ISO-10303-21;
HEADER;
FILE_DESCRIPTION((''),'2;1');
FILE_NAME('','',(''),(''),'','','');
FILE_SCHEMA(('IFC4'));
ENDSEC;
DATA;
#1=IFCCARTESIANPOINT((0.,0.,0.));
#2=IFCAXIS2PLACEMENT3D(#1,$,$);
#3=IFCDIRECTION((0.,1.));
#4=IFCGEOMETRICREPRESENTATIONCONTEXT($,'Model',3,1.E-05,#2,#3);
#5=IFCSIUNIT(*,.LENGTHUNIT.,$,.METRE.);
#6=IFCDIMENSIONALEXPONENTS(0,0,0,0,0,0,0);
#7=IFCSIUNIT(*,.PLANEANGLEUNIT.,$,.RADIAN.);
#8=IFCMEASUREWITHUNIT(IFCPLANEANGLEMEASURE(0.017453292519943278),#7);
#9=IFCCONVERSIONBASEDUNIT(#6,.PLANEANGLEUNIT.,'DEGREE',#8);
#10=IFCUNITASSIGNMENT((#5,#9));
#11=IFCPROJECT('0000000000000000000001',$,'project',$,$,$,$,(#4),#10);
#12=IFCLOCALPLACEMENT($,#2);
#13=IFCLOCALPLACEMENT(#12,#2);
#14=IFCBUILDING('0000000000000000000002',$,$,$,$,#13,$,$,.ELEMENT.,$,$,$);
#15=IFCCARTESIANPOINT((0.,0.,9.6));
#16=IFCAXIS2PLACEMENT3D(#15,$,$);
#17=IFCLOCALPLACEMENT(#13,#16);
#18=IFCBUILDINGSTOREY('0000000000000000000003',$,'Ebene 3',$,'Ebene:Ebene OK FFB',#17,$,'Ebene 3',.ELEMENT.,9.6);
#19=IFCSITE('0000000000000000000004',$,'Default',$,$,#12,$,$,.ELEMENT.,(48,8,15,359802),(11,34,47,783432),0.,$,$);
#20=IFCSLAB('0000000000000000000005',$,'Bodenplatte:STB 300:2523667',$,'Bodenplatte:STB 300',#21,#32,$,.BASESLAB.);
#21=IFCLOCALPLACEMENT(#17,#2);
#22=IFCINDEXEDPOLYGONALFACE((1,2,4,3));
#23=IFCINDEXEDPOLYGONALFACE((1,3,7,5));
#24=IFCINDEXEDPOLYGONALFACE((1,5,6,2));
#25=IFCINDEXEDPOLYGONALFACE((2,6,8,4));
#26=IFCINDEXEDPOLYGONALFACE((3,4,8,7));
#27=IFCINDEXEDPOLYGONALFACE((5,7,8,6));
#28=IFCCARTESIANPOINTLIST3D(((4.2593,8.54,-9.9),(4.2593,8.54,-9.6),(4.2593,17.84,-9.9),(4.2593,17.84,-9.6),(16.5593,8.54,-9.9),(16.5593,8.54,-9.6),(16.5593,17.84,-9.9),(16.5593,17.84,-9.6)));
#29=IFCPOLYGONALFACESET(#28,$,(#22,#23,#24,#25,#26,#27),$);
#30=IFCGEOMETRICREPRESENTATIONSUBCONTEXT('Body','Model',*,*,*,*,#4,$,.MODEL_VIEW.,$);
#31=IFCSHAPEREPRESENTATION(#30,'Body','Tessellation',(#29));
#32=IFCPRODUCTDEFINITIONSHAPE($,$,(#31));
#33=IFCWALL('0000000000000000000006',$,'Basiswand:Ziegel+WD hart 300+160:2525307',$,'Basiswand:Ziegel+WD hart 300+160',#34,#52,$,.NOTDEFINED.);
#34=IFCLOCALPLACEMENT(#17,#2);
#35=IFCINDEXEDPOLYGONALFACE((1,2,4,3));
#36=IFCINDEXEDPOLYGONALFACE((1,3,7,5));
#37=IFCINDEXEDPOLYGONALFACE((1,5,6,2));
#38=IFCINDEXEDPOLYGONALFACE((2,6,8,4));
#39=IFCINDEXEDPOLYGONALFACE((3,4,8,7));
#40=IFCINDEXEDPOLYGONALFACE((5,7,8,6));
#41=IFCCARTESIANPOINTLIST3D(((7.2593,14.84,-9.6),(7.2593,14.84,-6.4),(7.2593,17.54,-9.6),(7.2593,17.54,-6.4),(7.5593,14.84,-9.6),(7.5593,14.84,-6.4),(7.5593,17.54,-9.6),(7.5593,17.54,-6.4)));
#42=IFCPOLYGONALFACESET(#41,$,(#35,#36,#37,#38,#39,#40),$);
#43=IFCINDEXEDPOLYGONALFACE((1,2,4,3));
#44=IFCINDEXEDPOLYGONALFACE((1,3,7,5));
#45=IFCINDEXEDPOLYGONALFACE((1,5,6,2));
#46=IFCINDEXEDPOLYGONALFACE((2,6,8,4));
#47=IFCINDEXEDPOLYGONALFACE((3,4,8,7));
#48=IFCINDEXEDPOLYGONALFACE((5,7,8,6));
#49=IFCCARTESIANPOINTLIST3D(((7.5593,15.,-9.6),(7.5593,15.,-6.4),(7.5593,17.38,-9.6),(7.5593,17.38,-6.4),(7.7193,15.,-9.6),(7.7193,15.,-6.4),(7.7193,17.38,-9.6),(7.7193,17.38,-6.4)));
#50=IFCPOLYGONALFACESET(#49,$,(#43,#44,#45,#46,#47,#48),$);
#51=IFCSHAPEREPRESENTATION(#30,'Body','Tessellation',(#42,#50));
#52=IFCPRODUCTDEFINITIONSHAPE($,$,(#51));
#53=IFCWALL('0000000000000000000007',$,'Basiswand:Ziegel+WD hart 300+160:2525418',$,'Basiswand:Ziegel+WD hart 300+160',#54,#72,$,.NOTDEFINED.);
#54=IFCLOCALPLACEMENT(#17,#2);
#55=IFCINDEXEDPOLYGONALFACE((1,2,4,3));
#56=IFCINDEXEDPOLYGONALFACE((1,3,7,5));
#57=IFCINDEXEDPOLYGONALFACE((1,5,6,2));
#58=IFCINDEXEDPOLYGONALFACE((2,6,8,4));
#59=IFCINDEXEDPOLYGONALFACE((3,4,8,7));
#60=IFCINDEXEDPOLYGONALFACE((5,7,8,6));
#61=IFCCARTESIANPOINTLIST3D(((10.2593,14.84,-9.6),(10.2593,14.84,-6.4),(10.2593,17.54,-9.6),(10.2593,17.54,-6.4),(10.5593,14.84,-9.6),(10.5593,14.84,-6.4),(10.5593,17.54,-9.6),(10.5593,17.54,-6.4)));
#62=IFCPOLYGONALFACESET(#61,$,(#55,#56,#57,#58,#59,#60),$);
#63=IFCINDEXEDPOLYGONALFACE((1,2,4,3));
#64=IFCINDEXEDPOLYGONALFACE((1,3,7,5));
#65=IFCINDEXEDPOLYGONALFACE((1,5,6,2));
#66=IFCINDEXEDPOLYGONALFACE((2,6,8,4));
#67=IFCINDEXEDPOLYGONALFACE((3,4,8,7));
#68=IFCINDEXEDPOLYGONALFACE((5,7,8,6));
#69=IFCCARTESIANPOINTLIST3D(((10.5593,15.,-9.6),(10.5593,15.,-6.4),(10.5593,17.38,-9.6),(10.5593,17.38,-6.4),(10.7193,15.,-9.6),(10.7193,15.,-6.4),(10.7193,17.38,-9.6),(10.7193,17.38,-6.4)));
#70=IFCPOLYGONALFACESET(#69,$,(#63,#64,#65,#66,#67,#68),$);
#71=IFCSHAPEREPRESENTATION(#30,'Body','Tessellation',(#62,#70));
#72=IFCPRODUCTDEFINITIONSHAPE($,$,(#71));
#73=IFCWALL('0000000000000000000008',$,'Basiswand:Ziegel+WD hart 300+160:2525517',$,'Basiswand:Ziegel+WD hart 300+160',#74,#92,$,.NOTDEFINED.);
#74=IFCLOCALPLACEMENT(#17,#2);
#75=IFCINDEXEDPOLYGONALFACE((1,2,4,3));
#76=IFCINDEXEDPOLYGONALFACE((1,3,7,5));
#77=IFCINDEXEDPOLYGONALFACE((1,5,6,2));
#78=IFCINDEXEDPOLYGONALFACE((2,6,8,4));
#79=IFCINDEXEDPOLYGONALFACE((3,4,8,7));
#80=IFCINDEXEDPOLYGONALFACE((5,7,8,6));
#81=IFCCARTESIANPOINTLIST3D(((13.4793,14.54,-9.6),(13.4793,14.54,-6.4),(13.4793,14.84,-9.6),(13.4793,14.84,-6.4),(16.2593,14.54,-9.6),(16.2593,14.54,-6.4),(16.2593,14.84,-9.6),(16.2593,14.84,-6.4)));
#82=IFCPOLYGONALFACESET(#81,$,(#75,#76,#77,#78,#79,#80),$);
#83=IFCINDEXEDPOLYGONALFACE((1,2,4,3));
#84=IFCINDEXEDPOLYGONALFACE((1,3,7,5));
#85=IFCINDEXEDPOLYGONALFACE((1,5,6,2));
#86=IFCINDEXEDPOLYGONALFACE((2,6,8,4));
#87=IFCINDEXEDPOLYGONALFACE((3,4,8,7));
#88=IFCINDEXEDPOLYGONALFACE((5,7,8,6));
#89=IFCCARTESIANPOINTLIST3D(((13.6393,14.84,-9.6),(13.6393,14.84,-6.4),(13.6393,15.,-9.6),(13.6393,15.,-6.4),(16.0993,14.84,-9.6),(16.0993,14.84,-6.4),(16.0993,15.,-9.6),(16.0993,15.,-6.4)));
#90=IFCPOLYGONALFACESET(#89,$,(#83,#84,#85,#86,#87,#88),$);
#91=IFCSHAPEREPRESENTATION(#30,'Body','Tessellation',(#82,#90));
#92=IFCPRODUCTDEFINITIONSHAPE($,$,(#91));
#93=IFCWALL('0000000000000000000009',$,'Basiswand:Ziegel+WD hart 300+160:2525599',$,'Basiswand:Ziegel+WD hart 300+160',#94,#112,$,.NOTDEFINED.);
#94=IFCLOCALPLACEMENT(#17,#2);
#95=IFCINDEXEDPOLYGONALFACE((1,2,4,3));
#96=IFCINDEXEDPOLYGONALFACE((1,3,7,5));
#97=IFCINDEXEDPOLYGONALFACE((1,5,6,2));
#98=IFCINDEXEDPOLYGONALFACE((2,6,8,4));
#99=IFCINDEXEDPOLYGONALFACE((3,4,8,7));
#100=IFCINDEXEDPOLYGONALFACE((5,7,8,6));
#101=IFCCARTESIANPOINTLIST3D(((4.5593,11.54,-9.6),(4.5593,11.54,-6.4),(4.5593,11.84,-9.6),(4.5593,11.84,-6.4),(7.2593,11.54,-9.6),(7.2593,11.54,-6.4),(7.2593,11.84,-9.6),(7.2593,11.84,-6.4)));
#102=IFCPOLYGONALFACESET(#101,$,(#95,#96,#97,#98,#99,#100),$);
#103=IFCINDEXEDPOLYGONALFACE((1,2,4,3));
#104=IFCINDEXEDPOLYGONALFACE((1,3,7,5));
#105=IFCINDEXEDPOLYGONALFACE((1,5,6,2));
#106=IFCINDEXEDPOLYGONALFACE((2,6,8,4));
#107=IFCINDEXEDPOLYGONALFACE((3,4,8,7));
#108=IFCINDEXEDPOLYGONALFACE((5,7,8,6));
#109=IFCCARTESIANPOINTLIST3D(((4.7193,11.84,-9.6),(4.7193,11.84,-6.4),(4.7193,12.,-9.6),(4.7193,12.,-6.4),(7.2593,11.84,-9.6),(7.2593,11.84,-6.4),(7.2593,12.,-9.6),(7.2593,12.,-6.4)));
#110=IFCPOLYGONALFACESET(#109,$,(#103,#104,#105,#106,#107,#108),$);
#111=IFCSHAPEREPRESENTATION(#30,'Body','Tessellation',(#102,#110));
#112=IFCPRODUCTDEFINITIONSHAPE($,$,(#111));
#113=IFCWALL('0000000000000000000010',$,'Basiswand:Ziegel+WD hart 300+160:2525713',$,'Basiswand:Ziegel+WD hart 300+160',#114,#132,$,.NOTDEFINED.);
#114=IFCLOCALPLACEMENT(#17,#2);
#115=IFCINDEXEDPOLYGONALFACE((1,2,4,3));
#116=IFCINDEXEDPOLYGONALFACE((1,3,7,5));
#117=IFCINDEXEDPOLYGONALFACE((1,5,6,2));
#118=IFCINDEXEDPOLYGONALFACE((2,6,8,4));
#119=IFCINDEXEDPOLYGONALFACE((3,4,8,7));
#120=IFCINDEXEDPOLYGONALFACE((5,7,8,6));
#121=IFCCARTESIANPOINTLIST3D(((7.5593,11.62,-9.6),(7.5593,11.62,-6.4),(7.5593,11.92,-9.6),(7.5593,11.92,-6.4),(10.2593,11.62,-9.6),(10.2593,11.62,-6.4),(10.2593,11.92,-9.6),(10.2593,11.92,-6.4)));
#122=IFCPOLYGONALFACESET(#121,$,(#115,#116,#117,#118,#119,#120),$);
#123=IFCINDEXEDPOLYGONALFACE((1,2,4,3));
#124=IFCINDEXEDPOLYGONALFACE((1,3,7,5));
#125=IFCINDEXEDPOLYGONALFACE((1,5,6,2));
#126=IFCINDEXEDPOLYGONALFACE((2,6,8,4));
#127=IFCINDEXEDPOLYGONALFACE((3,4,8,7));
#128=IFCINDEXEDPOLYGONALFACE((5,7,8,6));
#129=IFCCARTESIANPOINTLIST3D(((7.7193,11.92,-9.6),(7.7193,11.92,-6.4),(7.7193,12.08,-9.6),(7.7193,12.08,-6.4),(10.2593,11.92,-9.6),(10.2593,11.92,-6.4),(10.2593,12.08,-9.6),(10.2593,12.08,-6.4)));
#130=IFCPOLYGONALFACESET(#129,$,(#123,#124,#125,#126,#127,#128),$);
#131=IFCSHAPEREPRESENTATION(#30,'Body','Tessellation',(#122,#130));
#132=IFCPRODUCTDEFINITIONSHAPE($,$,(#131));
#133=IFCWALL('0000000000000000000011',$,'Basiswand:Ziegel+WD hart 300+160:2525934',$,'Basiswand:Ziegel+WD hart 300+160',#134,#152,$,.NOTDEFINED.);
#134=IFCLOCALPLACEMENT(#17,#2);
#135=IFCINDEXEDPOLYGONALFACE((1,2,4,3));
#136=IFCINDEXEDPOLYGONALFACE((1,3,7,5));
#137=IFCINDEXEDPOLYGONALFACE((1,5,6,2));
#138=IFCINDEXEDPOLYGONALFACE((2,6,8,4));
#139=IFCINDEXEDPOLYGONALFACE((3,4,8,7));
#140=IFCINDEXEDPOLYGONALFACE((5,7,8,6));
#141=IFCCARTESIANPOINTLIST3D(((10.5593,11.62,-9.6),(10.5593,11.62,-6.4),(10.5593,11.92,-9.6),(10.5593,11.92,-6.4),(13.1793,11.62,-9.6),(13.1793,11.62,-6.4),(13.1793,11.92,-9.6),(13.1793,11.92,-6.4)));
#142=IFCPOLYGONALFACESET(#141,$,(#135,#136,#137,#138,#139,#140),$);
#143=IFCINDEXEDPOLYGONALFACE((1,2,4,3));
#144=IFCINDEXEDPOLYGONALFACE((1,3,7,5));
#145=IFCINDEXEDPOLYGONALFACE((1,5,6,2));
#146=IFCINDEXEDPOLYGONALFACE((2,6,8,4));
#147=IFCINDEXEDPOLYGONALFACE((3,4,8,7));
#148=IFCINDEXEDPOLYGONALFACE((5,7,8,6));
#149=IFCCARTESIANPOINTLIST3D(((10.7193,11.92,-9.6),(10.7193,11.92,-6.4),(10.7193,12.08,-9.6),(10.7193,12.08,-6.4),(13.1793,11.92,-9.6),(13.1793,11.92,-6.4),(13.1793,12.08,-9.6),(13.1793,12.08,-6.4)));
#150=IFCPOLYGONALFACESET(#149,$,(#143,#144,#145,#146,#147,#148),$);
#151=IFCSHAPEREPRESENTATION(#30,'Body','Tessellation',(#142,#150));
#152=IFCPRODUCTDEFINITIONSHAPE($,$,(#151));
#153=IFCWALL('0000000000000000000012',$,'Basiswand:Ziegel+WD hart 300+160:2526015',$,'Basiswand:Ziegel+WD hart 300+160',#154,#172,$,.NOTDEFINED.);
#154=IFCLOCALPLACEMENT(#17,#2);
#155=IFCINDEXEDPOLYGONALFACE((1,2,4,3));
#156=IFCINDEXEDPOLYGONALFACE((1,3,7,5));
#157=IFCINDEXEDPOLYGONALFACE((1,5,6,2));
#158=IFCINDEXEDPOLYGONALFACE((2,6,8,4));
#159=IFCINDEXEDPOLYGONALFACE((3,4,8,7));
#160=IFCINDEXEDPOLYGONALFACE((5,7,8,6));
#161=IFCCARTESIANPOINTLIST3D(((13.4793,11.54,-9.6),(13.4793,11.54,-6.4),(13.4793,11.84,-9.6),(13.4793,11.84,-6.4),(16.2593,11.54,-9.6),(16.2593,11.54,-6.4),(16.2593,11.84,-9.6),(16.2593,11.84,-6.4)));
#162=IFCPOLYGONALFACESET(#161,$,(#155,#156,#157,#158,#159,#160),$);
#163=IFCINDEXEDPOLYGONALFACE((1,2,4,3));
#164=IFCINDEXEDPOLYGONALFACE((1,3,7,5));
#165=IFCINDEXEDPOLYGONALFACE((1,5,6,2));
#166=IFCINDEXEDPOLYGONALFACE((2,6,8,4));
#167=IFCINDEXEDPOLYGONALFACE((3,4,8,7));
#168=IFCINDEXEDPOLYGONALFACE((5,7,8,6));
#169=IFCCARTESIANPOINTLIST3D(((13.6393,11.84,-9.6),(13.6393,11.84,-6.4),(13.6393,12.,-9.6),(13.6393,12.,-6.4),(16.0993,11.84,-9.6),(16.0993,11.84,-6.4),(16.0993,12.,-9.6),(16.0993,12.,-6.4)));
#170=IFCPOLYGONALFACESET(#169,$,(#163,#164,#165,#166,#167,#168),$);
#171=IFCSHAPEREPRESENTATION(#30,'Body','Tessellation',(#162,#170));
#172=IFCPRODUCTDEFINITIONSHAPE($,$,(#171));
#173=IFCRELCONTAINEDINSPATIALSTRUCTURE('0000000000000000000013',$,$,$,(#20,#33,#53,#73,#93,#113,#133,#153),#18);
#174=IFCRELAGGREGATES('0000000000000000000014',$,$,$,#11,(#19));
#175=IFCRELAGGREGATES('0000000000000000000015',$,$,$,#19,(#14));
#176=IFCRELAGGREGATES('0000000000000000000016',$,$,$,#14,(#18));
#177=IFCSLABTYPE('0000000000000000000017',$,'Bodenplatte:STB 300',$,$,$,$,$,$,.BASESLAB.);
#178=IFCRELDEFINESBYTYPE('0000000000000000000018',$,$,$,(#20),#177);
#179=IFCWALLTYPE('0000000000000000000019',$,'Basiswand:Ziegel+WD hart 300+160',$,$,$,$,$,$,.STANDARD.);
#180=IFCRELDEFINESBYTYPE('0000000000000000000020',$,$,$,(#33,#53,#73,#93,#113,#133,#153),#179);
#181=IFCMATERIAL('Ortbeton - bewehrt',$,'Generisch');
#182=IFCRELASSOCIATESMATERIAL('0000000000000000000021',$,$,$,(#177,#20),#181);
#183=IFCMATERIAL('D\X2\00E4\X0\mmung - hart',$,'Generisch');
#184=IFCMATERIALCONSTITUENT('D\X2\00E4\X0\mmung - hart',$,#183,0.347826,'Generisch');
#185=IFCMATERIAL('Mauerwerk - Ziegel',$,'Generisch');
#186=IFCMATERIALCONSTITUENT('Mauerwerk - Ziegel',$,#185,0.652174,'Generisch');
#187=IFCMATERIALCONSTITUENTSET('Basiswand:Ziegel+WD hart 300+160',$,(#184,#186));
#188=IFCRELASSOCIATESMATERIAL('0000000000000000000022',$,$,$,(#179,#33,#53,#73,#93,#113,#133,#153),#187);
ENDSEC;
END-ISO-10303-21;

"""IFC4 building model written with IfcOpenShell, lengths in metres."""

from ifc_helpers import new_model, entity, si_unit, converted_unit, direction, frame, origin, place, context, subcontext, project, spatial, indexed_curve, outline, extrude, material, constituent, constituent_set, type_object, element, save


model = new_model("IFC4")

# Units and contexts
model_context = context("Model", 3, precision=1e-05, world=origin(), true_north=direction((0.0, 1.0)))
body_context = subcontext(model_context, "Body", "Model", "MODEL_VIEW")
ifc_project = project(units=[si_unit("LENGTHUNIT", "METRE"), converted_unit("PLANEANGLEUNIT", "DEGREE", entity("IfcPlaneAngleMeasure", 0.017453292519943278), si_unit("PLANEANGLEUNIT", "RADIAN"), dimensions=[0, 0, 0, 0, 0, 0, 0])], contexts=[model_context])

# Site, building, storey
site_placement = place(None, origin())
site = spatial("IfcSite", under=ifc_project, at=site_placement, Name="Default", CompositionType="ELEMENT", RefLatitude=(48, 8, 15, 359802), RefLongitude=(11, 34, 47, 783432), RefElevation=0.0)
building_placement = place(site_placement, origin())
building = spatial("IfcBuilding", under=site, at=building_placement, CompositionType="ELEMENT")
storey_placement = place(building_placement, frame((0.0, 0.0, 9.6)))
storey = spatial("IfcBuildingStorey", under=building, at=storey_placement, Name="Ebene 3", ObjectType="Ebene:Ebene OK FFB", LongName="Ebene 3", CompositionType="ELEMENT", Elevation=9.6)

# Slab
ifc_material_1 = material(Name="Ortbeton - bewehrt", Category="Generisch")
slab_type = type_object("IfcSlabType", Name="Bodenplatte:STB 300", PredefinedType="BASESLAB", material=ifc_material_1)
slab_placement = place(storey_placement, origin())
element("IfcSlab", 1, at=slab_placement, inside=storey, type_object=slab_type, material=ifc_material_1, Name="Bodenplatte:STB 300:2523667", ObjectType="Bodenplatte:STB 300", PredefinedType="BASESLAB", context=body_context, shape_type="SweptSolid", body=[
    extrude(outline(indexed_curve([(-4.65, -6.15), (4.65, -6.15), (4.65, 6.15), (-4.65, 6.15), (-4.65, -6.15)], self_intersect=False)), frame((10.4093, 13.19, -9.6), z_axis=(0.0, 0.0, -1.0), x_axis=(0.0, 1.0, 0.0)), (0.0, 0.0, 1.0), 0.3),
])

# Walls
ifc_material_2 = material(Name="Dämmung - hart", Category="Generisch")
ifc_constituent_1 = constituent(ifc_material_2, Name="Dämmung - hart", Category="Generisch", fraction=0.347826)
ifc_material_3 = material(Name="Mauerwerk - Ziegel", Category="Generisch")
ifc_constituent_2 = constituent(ifc_material_3, Name="Mauerwerk - Ziegel", Category="Generisch", fraction=0.652174)
ifc_constituent_set = constituent_set(constituents=[ifc_constituent_1, ifc_constituent_2], Name="Basiswand:Ziegel+WD hart 300+160")
wall_type = type_object("IfcWallType", Name="Basiswand:Ziegel+WD hart 300+160", PredefinedType="STANDARD", material=ifc_constituent_set)
wall_1_placement = place(storey_placement, frame((7.4893, 17.38, -9.6), z_axis=(0.0, 0.0, 1.0), x_axis=(0.0, -1.0, 0.0)))
element("IfcWall", 2, at=wall_1_placement, inside=storey, type_object=wall_type, material=ifc_constituent_set, Name="Basiswand:Ziegel+WD hart 300+160:2525307", ObjectType="Basiswand:Ziegel+WD hart 300+160", PredefinedType="NOTDEFINED", context=body_context, shape_type="SweptSolid", body=[
    extrude(outline(indexed_curve([(-0.15, -1.35), (0.15, -1.35), (0.15, 1.35), (-0.15, 1.35), (-0.15, -1.35)], self_intersect=False)), frame((1.19, -0.08, 0.0), z_axis=(0.0, 0.0, 1.0), x_axis=(0.0, 1.0, 0.0)), (0.0, 0.0, 1.0), 3.2),
    extrude(outline(indexed_curve([(-0.08, -1.19), (0.08, -1.19), (0.08, 1.19), (-0.08, 1.19), (-0.08, -1.19)], self_intersect=False)), frame((1.19, 0.15, 0.0), z_axis=(0.0, 0.0, 1.0), x_axis=(0.0, -1.0, 0.0)), (0.0, 0.0, 1.0), 3.2),
])
wall_2_placement = place(storey_placement, frame((10.4893, 17.38, -9.6), z_axis=(0.0, 0.0, 1.0), x_axis=(0.0, -1.0, 0.0)))
element("IfcWall", 3, at=wall_2_placement, inside=storey, type_object=wall_type, material=ifc_constituent_set, Name="Basiswand:Ziegel+WD hart 300+160:2525418", ObjectType="Basiswand:Ziegel+WD hart 300+160", PredefinedType="NOTDEFINED", context=body_context, shape_type="SweptSolid", body=[
    extrude(outline(indexed_curve([(-0.15, -1.35), (0.15, -1.35), (0.15, 1.35), (-0.15, 1.35), (-0.15, -1.35)], self_intersect=False)), frame((1.19, -0.08, 0.0), z_axis=(0.0, 0.0, 1.0), x_axis=(0.0, 1.0, 0.0)), (0.0, 0.0, 1.0), 3.2),
    extrude(outline(indexed_curve([(-0.08, -1.19), (0.08, -1.19), (0.08, 1.19), (-0.08, 1.19), (-0.08, -1.19)], self_intersect=False)), frame((1.19, 0.15, 0.0), z_axis=(0.0, 0.0, 1.0), x_axis=(0.0, -1.0, 0.0)), (0.0, 0.0, 1.0), 3.2),
])
wall_3_placement = place(storey_placement, frame((13.6393, 14.77, -9.6)))
element("IfcWall", 4, at=wall_3_placement, inside=storey, type_object=wall_type, material=ifc_constituent_set, Name="Basiswand:Ziegel+WD hart 300+160:2525517", ObjectType="Basiswand:Ziegel+WD hart 300+160", PredefinedType="NOTDEFINED", context=body_context, shape_type="SweptSolid", body=[
    extrude(outline(indexed_curve([(-0.15, -1.39), (0.15, -1.39), (0.15, 1.39), (-0.15, 1.39), (-0.15, -1.39)], self_intersect=False)), frame((1.23, -0.08, 0.0), z_axis=(0.0, 0.0, 1.0), x_axis=(0.0, 1.0, 0.0)), (0.0, 0.0, 1.0), 3.2),
    extrude(outline(indexed_curve([(-0.08, -1.23), (0.08, -1.23), (0.08, 1.23), (-0.08, 1.23), (-0.08, -1.23)], self_intersect=False)), frame((1.23, 0.15, 0.0), z_axis=(0.0, 0.0, 1.0), x_axis=(0.0, -1.0, 0.0)), (0.0, 0.0, 1.0), 3.2),
])
wall_4_placement = place(storey_placement, frame((4.7193, 11.77, -9.6)))
element("IfcWall", 5, at=wall_4_placement, inside=storey, type_object=wall_type, material=ifc_constituent_set, Name="Basiswand:Ziegel+WD hart 300+160:2525599", ObjectType="Basiswand:Ziegel+WD hart 300+160", PredefinedType="NOTDEFINED", context=body_context, shape_type="SweptSolid", body=[
    extrude(outline(indexed_curve([(-0.15, -1.35), (0.15, -1.35), (0.15, 1.35), (-0.15, 1.35), (-0.15, -1.35)], self_intersect=False)), frame((1.19, -0.08, 0.0), z_axis=(0.0, 0.0, 1.0), x_axis=(0.0, 1.0, 0.0)), (0.0, 0.0, 1.0), 3.2),
    extrude(outline(indexed_curve([(-0.08, -1.27), (0.08, -1.27), (0.08, 1.27), (-0.08, 1.27), (-0.08, -1.27)], self_intersect=False)), frame((1.27, 0.15, 0.0), z_axis=(0.0, 0.0, 1.0), x_axis=(0.0, -1.0, 0.0)), (0.0, 0.0, 1.0), 3.2),
])
wall_5_placement = place(storey_placement, frame((7.7193, 11.85, -9.6)))
element("IfcWall", 6, at=wall_5_placement, inside=storey, type_object=wall_type, material=ifc_constituent_set, Name="Basiswand:Ziegel+WD hart 300+160:2525713", ObjectType="Basiswand:Ziegel+WD hart 300+160", PredefinedType="NOTDEFINED", context=body_context, shape_type="SweptSolid", body=[
    extrude(outline(indexed_curve([(-0.15, -1.35), (0.15, -1.35), (0.15, 1.35), (-0.15, 1.35), (-0.15, -1.35)], self_intersect=False)), frame((1.19, -0.08, 0.0), z_axis=(0.0, 0.0, 1.0), x_axis=(0.0, 1.0, 0.0)), (0.0, 0.0, 1.0), 3.2),
    extrude(outline(indexed_curve([(-0.08, -1.27), (0.08, -1.27), (0.08, 1.27), (-0.08, 1.27), (-0.08, -1.27)], self_intersect=False)), frame((1.27, 0.15, 0.0), z_axis=(0.0, 0.0, 1.0), x_axis=(0.0, -1.0, 0.0)), (0.0, 0.0, 1.0), 3.2),
])
wall_6_placement = place(storey_placement, frame((10.7193, 11.85, -9.6)))
element("IfcWall", 7, at=wall_6_placement, inside=storey, type_object=wall_type, material=ifc_constituent_set, Name="Basiswand:Ziegel+WD hart 300+160:2525934", ObjectType="Basiswand:Ziegel+WD hart 300+160", PredefinedType="NOTDEFINED", context=body_context, shape_type="SweptSolid", body=[
    extrude(outline(indexed_curve([(-0.15, -1.31), (0.15, -1.31), (0.15, 1.31), (-0.15, 1.31), (-0.15, -1.31)], self_intersect=False)), frame((1.15, -0.08, 0.0), z_axis=(0.0, 0.0, 1.0), x_axis=(0.0, 1.0, 0.0)), (0.0, 0.0, 1.0), 3.2),
    extrude(outline(indexed_curve([(-0.08, -1.23), (0.08, -1.23), (0.08, 1.23), (-0.08, 1.23), (-0.08, -1.23)], self_intersect=False)), frame((1.23, 0.15, 0.0), z_axis=(0.0, 0.0, 1.0), x_axis=(0.0, -1.0, 0.0)), (0.0, 0.0, 1.0), 3.2),
])
wall_7_placement = place(storey_placement, frame((13.6393, 11.77, -9.6)))
element("IfcWall", 8, at=wall_7_placement, inside=storey, type_object=wall_type, material=ifc_constituent_set, Name="Basiswand:Ziegel+WD hart 300+160:2526015", ObjectType="Basiswand:Ziegel+WD hart 300+160", PredefinedType="NOTDEFINED", context=body_context, shape_type="SweptSolid", body=[
    extrude(outline(indexed_curve([(-0.15, -1.39), (0.15, -1.39), (0.15, 1.39), (-0.15, 1.39), (-0.15, -1.39)], self_intersect=False)), frame((1.23, -0.08, 0.0), z_axis=(0.0, 0.0, 1.0), x_axis=(0.0, 1.0, 0.0)), (0.0, 0.0, 1.0), 3.2),
    extrude(outline(indexed_curve([(-0.08, -1.23), (0.08, -1.23), (0.08, 1.23), (-0.08, 1.23), (-0.08, -1.23)], self_intersect=False)), frame((1.23, 0.15, 0.0), z_axis=(0.0, 0.0, 1.0), x_axis=(0.0, -1.0, 0.0)), (0.0, 0.0, 1.0), 3.2),
])

save(model, "model.ifc")
